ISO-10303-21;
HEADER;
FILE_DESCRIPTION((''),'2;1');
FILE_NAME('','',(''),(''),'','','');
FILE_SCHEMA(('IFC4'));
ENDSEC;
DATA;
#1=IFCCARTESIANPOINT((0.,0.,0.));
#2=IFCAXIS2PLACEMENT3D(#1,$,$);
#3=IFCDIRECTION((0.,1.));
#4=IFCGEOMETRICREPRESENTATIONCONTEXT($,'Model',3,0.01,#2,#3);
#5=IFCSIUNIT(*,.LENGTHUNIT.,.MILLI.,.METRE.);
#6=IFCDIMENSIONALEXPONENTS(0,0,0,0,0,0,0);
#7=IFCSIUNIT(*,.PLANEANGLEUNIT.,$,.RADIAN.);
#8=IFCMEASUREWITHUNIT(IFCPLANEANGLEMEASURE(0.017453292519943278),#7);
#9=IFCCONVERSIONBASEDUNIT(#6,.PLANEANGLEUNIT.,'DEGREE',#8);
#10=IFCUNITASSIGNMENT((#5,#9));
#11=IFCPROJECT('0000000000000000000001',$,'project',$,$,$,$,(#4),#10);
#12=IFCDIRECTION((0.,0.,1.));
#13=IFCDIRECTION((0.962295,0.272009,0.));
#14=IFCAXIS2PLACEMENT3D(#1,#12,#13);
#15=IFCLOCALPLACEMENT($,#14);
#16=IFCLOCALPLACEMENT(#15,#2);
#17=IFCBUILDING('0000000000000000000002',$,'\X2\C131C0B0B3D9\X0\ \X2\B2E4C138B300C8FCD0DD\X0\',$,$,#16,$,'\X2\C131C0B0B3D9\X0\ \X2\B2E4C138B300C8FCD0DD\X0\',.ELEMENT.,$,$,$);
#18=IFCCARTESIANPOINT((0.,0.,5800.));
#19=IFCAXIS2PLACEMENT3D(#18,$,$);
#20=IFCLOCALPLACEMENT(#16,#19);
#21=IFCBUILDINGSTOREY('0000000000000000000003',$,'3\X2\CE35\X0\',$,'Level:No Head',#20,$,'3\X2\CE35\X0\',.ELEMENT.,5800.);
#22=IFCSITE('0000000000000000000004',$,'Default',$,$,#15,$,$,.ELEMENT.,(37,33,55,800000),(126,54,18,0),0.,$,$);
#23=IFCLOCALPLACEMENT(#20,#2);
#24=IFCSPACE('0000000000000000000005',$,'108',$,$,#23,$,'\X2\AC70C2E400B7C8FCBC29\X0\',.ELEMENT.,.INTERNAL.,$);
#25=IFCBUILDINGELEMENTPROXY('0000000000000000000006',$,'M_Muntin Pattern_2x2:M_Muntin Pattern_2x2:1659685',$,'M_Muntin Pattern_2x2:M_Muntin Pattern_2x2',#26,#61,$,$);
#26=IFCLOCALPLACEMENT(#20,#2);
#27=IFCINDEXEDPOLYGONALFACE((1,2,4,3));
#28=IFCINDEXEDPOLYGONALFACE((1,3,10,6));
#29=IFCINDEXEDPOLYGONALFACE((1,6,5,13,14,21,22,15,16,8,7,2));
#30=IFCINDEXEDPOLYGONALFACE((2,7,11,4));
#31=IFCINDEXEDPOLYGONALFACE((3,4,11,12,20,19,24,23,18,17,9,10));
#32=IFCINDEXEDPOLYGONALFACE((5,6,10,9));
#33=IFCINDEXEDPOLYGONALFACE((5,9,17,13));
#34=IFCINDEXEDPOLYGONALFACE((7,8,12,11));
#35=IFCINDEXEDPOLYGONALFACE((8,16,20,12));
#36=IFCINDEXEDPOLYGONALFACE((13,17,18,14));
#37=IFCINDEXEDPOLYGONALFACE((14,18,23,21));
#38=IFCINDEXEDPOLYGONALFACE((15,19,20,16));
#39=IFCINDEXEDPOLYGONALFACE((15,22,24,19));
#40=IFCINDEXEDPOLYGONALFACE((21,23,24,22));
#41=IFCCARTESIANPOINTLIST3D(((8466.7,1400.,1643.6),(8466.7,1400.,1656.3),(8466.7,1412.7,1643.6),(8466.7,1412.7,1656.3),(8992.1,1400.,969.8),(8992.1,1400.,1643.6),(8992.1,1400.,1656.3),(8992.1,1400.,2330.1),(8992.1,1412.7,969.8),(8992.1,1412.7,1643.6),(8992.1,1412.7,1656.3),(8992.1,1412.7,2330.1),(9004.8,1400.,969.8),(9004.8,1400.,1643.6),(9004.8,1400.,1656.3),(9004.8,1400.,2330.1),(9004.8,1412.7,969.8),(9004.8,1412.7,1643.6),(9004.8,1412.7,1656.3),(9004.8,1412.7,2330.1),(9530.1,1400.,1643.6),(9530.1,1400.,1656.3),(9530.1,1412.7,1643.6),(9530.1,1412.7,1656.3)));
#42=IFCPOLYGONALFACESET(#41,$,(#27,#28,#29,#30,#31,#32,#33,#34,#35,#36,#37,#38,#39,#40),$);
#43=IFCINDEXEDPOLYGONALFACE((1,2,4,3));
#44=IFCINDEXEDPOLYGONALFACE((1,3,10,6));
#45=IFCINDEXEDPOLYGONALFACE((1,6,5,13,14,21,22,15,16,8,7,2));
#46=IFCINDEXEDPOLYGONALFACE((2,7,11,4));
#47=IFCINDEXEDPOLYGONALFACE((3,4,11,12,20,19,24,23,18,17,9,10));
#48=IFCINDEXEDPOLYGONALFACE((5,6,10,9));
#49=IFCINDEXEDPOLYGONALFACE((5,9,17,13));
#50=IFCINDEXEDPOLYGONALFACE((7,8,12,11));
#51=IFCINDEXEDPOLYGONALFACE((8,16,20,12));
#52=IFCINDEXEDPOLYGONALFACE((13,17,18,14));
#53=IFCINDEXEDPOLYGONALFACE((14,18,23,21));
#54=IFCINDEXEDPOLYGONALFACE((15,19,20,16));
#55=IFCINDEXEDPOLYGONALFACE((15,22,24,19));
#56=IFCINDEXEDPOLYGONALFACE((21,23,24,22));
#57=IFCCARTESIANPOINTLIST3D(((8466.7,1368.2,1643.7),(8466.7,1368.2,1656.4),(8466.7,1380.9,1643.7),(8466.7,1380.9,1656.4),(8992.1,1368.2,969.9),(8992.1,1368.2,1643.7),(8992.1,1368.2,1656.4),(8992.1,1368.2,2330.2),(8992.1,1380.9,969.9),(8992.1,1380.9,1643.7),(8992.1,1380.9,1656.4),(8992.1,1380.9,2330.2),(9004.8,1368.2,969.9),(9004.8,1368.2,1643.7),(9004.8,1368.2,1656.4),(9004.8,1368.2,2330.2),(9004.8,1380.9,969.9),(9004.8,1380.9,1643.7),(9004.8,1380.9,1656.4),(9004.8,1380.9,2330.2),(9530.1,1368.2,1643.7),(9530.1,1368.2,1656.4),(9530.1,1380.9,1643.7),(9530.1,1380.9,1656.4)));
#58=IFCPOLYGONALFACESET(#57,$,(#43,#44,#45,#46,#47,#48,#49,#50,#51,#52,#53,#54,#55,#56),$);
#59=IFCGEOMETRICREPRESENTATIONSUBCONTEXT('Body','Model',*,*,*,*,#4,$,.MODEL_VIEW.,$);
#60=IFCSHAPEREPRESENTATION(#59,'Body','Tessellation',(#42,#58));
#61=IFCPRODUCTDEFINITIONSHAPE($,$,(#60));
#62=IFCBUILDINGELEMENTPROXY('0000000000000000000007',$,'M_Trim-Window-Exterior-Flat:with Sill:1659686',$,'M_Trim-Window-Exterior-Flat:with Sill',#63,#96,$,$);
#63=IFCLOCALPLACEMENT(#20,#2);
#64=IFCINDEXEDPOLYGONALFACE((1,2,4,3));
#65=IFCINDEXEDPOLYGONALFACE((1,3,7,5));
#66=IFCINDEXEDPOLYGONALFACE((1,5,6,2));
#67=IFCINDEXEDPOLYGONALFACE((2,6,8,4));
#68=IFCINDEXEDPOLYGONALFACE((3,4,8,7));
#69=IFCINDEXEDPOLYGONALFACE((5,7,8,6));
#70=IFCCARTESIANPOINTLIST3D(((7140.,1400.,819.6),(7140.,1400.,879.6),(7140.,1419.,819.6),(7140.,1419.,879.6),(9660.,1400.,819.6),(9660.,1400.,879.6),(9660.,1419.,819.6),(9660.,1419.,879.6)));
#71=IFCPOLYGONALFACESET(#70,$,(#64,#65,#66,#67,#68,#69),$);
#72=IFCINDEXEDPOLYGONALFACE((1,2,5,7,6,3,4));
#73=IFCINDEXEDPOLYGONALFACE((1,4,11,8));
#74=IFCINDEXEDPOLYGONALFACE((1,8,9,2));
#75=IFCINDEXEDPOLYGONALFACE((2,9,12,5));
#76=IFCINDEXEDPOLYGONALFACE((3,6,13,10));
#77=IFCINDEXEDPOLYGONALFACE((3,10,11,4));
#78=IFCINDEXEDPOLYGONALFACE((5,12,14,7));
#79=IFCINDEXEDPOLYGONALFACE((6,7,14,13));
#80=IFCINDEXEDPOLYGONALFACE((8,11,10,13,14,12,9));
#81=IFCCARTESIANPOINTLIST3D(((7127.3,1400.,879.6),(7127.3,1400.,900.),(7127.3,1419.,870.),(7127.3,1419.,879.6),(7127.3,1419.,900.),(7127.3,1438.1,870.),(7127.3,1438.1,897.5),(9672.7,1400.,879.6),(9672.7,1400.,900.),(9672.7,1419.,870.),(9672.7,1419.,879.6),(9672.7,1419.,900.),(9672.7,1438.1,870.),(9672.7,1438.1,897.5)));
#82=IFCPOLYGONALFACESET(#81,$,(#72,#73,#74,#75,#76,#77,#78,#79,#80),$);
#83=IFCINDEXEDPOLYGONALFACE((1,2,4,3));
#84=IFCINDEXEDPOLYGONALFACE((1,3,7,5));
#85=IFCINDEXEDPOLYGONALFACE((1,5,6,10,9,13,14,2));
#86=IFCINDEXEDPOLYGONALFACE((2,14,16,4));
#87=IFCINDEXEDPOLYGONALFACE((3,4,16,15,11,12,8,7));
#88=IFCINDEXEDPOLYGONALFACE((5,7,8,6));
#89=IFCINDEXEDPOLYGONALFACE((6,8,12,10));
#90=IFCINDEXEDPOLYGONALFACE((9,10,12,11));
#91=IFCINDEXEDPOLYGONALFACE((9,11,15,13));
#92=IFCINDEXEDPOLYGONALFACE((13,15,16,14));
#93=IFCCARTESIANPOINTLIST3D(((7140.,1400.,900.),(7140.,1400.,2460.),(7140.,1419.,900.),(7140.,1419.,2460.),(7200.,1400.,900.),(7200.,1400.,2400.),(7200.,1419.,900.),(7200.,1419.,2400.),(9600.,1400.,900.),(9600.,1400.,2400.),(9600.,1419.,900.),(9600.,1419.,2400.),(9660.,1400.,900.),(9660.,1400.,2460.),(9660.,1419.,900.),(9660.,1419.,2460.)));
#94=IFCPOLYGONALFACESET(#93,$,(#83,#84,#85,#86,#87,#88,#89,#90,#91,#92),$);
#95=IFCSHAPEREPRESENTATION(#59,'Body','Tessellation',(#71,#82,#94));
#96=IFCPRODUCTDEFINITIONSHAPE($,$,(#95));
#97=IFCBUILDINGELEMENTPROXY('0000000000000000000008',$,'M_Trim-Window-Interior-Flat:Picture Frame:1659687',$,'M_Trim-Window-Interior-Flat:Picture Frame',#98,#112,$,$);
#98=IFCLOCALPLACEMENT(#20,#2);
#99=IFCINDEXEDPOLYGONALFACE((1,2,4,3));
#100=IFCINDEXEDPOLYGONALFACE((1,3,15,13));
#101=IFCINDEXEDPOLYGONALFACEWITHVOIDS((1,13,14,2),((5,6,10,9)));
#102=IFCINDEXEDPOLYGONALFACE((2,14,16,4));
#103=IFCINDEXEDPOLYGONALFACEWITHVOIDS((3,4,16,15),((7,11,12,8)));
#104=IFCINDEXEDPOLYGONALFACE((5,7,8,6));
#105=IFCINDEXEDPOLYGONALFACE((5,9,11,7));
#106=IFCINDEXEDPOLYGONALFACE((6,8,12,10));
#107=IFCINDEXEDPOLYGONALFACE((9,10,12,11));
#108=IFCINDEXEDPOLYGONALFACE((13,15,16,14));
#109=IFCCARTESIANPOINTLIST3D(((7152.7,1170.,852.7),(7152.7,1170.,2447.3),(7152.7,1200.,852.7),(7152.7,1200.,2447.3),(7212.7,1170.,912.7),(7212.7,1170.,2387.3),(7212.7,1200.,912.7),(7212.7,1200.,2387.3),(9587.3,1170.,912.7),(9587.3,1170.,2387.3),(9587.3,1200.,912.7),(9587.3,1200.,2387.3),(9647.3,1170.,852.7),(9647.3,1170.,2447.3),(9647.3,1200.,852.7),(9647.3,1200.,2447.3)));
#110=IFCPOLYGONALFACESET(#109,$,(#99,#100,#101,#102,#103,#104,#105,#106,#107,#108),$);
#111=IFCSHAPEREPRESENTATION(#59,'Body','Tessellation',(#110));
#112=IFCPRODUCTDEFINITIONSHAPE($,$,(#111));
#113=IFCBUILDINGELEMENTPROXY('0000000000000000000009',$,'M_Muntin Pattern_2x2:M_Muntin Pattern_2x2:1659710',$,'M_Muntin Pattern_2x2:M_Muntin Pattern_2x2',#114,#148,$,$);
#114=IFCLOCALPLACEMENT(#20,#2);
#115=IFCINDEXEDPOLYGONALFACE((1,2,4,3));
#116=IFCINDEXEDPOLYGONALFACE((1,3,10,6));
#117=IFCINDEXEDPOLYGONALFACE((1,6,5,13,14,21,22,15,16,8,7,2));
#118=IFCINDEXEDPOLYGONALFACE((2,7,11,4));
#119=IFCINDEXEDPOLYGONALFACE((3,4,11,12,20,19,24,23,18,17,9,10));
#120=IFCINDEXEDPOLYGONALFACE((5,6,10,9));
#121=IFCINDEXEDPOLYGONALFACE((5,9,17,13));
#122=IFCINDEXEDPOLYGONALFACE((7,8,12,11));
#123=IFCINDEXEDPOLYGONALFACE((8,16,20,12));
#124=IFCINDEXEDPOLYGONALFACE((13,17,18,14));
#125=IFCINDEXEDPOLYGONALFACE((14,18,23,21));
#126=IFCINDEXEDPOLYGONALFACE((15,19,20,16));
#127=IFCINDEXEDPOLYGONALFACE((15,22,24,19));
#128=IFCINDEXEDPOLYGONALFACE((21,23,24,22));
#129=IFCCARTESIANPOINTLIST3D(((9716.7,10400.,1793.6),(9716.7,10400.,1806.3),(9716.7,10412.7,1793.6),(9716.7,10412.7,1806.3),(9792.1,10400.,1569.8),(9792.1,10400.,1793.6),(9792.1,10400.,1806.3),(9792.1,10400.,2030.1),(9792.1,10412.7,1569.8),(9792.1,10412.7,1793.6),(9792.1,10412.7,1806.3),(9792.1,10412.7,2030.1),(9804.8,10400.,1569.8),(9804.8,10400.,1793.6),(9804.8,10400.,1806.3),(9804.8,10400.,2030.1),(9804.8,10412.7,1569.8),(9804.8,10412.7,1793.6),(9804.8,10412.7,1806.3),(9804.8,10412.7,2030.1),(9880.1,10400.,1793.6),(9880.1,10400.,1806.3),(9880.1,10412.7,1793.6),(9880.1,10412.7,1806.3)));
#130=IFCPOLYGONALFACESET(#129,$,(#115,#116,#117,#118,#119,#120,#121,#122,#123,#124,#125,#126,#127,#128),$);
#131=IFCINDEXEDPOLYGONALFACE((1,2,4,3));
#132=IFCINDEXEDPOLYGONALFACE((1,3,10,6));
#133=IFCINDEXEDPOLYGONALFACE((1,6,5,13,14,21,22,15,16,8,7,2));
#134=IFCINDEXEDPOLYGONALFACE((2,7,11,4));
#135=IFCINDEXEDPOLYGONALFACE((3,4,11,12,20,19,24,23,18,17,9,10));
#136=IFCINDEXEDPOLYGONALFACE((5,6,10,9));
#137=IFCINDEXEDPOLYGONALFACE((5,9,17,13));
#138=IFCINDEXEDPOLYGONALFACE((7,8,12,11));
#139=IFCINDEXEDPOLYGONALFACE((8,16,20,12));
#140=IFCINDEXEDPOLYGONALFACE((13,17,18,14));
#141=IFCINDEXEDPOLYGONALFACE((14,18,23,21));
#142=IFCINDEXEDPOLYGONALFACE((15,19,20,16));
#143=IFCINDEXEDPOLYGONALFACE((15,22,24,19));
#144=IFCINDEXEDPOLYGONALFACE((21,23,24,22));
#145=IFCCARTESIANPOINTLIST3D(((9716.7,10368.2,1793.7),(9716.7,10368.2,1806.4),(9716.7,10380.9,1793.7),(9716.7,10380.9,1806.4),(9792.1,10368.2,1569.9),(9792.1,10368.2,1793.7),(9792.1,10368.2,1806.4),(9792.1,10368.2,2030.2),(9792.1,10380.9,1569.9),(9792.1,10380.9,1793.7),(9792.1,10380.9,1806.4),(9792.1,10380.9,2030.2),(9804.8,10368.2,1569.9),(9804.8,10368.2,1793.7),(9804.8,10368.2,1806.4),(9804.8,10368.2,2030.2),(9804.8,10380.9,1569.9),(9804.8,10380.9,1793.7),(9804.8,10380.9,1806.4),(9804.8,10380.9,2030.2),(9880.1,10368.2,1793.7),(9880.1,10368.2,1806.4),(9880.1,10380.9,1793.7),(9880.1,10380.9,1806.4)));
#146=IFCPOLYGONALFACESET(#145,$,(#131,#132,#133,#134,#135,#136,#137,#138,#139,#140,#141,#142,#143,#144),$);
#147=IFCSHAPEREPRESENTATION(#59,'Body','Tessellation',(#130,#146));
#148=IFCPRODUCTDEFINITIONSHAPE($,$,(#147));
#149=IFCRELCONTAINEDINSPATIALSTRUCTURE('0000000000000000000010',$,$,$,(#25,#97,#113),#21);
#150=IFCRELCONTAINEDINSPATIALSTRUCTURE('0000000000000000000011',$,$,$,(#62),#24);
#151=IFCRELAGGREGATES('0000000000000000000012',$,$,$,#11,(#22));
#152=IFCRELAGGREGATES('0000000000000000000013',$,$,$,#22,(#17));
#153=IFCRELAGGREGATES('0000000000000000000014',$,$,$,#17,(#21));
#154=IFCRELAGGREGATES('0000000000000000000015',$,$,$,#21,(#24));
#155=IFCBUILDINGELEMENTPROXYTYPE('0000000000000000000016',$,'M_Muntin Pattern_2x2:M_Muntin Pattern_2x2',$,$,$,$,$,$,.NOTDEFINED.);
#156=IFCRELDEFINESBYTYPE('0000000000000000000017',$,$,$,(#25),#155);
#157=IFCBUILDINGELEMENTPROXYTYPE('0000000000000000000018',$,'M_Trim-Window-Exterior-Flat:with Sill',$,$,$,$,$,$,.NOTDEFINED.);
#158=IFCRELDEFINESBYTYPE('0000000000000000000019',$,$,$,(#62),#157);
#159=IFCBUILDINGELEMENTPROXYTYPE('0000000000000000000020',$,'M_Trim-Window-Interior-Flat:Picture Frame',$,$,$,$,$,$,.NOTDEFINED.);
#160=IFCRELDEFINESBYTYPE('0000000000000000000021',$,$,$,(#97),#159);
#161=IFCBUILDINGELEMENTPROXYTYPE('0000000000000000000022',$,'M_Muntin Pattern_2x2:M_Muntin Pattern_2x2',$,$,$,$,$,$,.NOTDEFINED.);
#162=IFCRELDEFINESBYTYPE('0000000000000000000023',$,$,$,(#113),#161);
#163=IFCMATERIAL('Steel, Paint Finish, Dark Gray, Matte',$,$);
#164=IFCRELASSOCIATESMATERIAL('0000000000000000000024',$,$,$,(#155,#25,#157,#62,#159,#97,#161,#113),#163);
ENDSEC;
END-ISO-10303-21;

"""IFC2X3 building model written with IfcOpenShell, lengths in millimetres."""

from ifc_helpers import new_model, entity, si_unit, converted_unit, direction, frame, frame_2d, origin, place, context, subcontext, project, spatial, polyline, rectangle, outline, extrude, source, transform, mapped, material, type_object, type_shapes, element, save


model = new_model("IFC2X3")

# Units and contexts
model_context = context("Model", 3, precision=0.01, world=origin(), true_north=direction((0.0, 1.0)))
body_context = subcontext(model_context, "Body", "Model", "MODEL_VIEW")
ifc_project = project(units=[si_unit("LENGTHUNIT", "METRE", prefix="MILLI"), converted_unit("PLANEANGLEUNIT", "DEGREE", entity("IfcPlaneAngleMeasure", 0.017453292519943278), si_unit("PLANEANGLEUNIT", "RADIAN"), dimensions=[0, 0, 0, 0, 0, 0, 0])], contexts=[model_context])

# Site, building, storey
site_placement = place(None, frame((0.0, 0.0, 0.0), z_axis=(0.0, 0.0, 1.0), x_axis=(0.962295, 0.272009, 0.0)))
site = spatial("IfcSite", under=ifc_project, at=site_placement, Name="Default", CompositionType="ELEMENT", RefLatitude=(37, 33, 55, 800000), RefLongitude=(126, 54, 18, 0), RefElevation=0.0)
building_placement = place(site_placement, origin())
building = spatial("IfcBuilding", under=site, at=building_placement, Name="성산동 다세대주택", LongName="성산동 다세대주택", CompositionType="ELEMENT")
storey_placement = place(building_placement, frame((0.0, 0.0, 5800.0)))
storey = spatial("IfcBuildingStorey", under=building, at=storey_placement, Name="3층", ObjectType="Level:No Head", LongName="3층", CompositionType="ELEMENT", Elevation=5800.0)

# Shared definitions
ifc_material_1 = material(Name="Steel, Paint Finish, Dark Gray, Matte")

# Shared definitions
space_1_placement = place(storey_placement, origin())
space_1 = spatial("IfcSpace", under=storey, at=space_1_placement, Name="108", LongName="거실·주방", CompositionType="ELEMENT", InteriorOrExteriorSpace="INTERNAL")

# Building element proxies
building_element_proxy_type_1 = type_object("IfcBuildingElementProxyType", Name="M_Muntin Pattern_2x2:M_Muntin Pattern_2x2", PredefinedType="NOTDEFINED", material=ifc_material_1)
shared_shape_1 = source(origin(), body_context, "Body", "SweptSolid", [
    extrude(outline(polyline([(6.4, -6.4), (680.1, -6.4), (680.1, 6.3), (6.4, 6.3), (6.4, 531.7), (-6.3, 531.7), (-6.3, 6.3), (-680.2, 6.3), (-680.2, -6.4), (-6.3, -6.4), (-6.3, -531.7), (6.4, -531.7), (6.4, -6.4)])), frame((0.0, -22.2, 680.1), z_axis=(0.0, 1.0, 0.0), x_axis=(0.0, 0.0, 1.0)), (0.0, 0.0, 1.0), 12.7),
    extrude(outline(polyline([(6.4, -6.4), (680.2, -6.4), (680.2, 6.3), (6.4, 6.3), (6.4, 531.7), (-6.3, 531.7), (-6.3, 6.3), (-680.2, 6.3), (-680.2, -6.4), (-6.3, -6.4), (-6.3, -531.7), (6.4, -531.7), (6.4, -6.4)])), frame((0.0, 9.5, 680.2), z_axis=(0.0, 1.0, 0.0), x_axis=(0.0, 0.0, 1.0)), (0.0, 0.0, 1.0), 12.7),
])
type_shapes(building_element_proxy_type_1, [shared_shape_1])
proxy_1_placement = place(storey_placement, frame((8998.4, 1390.5, 969.9), z_axis=(0.0, 0.0, 1.0), x_axis=(-1.0, 0.0, 0.0)))
element("IfcBuildingElementProxy", 1, at=proxy_1_placement, inside=storey, type_object=building_element_proxy_type_1, material=ifc_material_1, Name="M_Muntin Pattern_2x2:M_Muntin Pattern_2x2:1659685", ObjectType="M_Muntin Pattern_2x2:M_Muntin Pattern_2x2", context=body_context, shape_type="MappedRepresentation", body=[
    mapped(shared_shape_1, transform((0.0, 0.0, 0.0), scale=1.0)),
])
building_element_proxy_type_2 = type_object("IfcBuildingElementProxyType", Name="M_Trim-Window-Exterior-Flat:with Sill", PredefinedType="NOTDEFINED", material=ifc_material_1)
shared_shape_2 = source(origin(), body_context, "Body", "SweptSolid", [
    extrude(rectangle(XDim=2520.0, YDim=60.0, at=frame_2d((0.0, 0.0), x_axis=(1.0, 0.0))), frame((0.0, -1550.4, 0.0), z_axis=(0.0, 0.0, 1.0), x_axis=(-1.0, 0.0, 0.0)), (0.0, 0.0, 1.0), 19.0),
    extrude(outline(polyline([(-19.0, -15.2), (0.0, -15.2), (0.0, -5.7), (19.0, -5.7), (19.0, 14.8), (0.0, 14.8), (-19.0, 12.3), (-19.0, -15.2)])), frame((-1272.7, -1514.8, 19.0), z_axis=(1.0, 0.0, 0.0), x_axis=(0.0, 0.0, -1.0)), (0.0, 0.0, 1.0), 2545.4),
    extrude(outline(polyline([(-795.0, -1260.0), (765.0, -1260.0), (765.0, -1200.0), (-735.0, -1200.0), (-735.0, 1200.0), (765.0, 1200.0), (765.0, 1260.0), (-795.0, 1260.0), (-795.0, -1260.0)])), frame((0.0, -735.0, 0.0), z_axis=(0.0, 0.0, 1.0), x_axis=(0.0, -1.0, 0.0)), (0.0, 0.0, 1.0), 19.0),
])
type_shapes(building_element_proxy_type_2, [shared_shape_2])
proxy_2_placement = place(space_1_placement, frame((8400.0, 1400.0, 2400.0), z_axis=(0.0, 1.0, 0.0), x_axis=(-1.0, 0.0, 0.0)))
element("IfcBuildingElementProxy", 2, at=proxy_2_placement, inside=space_1, type_object=building_element_proxy_type_2, material=ifc_material_1, Name="M_Trim-Window-Exterior-Flat:with Sill:1659686", ObjectType="M_Trim-Window-Exterior-Flat:with Sill", context=body_context, shape_type="MappedRepresentation", body=[
    mapped(shared_shape_2, transform((0.0, 0.0, 0.0), scale=1.0)),
])
building_element_proxy_type_3 = type_object("IfcBuildingElementProxyType", Name="M_Trim-Window-Interior-Flat:Picture Frame", PredefinedType="NOTDEFINED", material=ifc_material_1)
shared_shape_3 = source(origin(), body_context, "Body", "SweptSolid", [
    extrude(outline(polyline([(-1247.3, -797.3), (1247.3, -797.3), (1247.3, 797.3), (-1247.3, 797.3), (-1247.3, -797.3)]), holes=[polyline([(-1187.3, -737.3), (-1187.3, 737.3), (1187.3, 737.3), (1187.3, -737.3), (-1187.3, -737.3)])]), frame((0.0, -750.0, 0.0), z_axis=(0.0, 0.0, 1.0), x_axis=(-1.0, 0.0, 0.0)), (0.0, 0.0, 1.0), 30.0),
])
type_shapes(building_element_proxy_type_3, [shared_shape_3])
proxy_3_placement = place(storey_placement, frame((8400.0, 1200.0, 2400.0), z_axis=(0.0, -1.0, 0.0), x_axis=(1.0, 0.0, 0.0)))
element("IfcBuildingElementProxy", 3, at=proxy_3_placement, inside=storey, type_object=building_element_proxy_type_3, material=ifc_material_1, Name="M_Trim-Window-Interior-Flat:Picture Frame:1659687", ObjectType="M_Trim-Window-Interior-Flat:Picture Frame", context=body_context, shape_type="MappedRepresentation", body=[
    mapped(shared_shape_3, transform((0.0, 0.0, 0.0), scale=1.0)),
])
building_element_proxy_type_4 = type_object("IfcBuildingElementProxyType", Name="M_Muntin Pattern_2x2:M_Muntin Pattern_2x2", PredefinedType="NOTDEFINED", material=ifc_material_1)
shared_shape_4 = source(origin(), body_context, "Body", "SweptSolid", [
    extrude(outline(polyline([(6.4, -6.4), (230.1, -6.4), (230.1, 6.3), (6.4, 6.3), (6.4, 81.7), (-6.3, 81.7), (-6.3, 6.3), (-230.2, 6.3), (-230.2, -6.4), (-6.3, -6.4), (-6.3, -81.7), (6.4, -81.7), (6.4, -6.4)])), frame((0.0, -22.2, 230.1), z_axis=(0.0, 1.0, 0.0), x_axis=(0.0, 0.0, 1.0)), (0.0, 0.0, 1.0), 12.7),
    extrude(outline(polyline([(6.4, -6.4), (230.2, -6.4), (230.2, 6.3), (6.4, 6.3), (6.4, 81.7), (-6.3, 81.7), (-6.3, 6.3), (-230.2, 6.3), (-230.2, -6.4), (-6.3, -6.4), (-6.3, -81.7), (6.4, -81.7), (6.4, -6.4)])), frame((0.0, 9.5, 230.2), z_axis=(0.0, 1.0, 0.0), x_axis=(0.0, 0.0, 1.0)), (0.0, 0.0, 1.0), 12.7),
])
type_shapes(building_element_proxy_type_4, [shared_shape_4])
proxy_4_placement = place(storey_placement, frame((9798.4, 10390.5, 1569.9), z_axis=(0.0, 0.0, 1.0), x_axis=(-1.0, 0.0, 0.0)))
element("IfcBuildingElementProxy", 4, at=proxy_4_placement, inside=storey, type_object=building_element_proxy_type_4, material=ifc_material_1, Name="M_Muntin Pattern_2x2:M_Muntin Pattern_2x2:1659710", ObjectType="M_Muntin Pattern_2x2:M_Muntin Pattern_2x2", context=body_context, shape_type="MappedRepresentation", body=[
    mapped(shared_shape_4, transform((0.0, 0.0, 0.0), scale=1.0)),
])

save(model, "model.ifc")
